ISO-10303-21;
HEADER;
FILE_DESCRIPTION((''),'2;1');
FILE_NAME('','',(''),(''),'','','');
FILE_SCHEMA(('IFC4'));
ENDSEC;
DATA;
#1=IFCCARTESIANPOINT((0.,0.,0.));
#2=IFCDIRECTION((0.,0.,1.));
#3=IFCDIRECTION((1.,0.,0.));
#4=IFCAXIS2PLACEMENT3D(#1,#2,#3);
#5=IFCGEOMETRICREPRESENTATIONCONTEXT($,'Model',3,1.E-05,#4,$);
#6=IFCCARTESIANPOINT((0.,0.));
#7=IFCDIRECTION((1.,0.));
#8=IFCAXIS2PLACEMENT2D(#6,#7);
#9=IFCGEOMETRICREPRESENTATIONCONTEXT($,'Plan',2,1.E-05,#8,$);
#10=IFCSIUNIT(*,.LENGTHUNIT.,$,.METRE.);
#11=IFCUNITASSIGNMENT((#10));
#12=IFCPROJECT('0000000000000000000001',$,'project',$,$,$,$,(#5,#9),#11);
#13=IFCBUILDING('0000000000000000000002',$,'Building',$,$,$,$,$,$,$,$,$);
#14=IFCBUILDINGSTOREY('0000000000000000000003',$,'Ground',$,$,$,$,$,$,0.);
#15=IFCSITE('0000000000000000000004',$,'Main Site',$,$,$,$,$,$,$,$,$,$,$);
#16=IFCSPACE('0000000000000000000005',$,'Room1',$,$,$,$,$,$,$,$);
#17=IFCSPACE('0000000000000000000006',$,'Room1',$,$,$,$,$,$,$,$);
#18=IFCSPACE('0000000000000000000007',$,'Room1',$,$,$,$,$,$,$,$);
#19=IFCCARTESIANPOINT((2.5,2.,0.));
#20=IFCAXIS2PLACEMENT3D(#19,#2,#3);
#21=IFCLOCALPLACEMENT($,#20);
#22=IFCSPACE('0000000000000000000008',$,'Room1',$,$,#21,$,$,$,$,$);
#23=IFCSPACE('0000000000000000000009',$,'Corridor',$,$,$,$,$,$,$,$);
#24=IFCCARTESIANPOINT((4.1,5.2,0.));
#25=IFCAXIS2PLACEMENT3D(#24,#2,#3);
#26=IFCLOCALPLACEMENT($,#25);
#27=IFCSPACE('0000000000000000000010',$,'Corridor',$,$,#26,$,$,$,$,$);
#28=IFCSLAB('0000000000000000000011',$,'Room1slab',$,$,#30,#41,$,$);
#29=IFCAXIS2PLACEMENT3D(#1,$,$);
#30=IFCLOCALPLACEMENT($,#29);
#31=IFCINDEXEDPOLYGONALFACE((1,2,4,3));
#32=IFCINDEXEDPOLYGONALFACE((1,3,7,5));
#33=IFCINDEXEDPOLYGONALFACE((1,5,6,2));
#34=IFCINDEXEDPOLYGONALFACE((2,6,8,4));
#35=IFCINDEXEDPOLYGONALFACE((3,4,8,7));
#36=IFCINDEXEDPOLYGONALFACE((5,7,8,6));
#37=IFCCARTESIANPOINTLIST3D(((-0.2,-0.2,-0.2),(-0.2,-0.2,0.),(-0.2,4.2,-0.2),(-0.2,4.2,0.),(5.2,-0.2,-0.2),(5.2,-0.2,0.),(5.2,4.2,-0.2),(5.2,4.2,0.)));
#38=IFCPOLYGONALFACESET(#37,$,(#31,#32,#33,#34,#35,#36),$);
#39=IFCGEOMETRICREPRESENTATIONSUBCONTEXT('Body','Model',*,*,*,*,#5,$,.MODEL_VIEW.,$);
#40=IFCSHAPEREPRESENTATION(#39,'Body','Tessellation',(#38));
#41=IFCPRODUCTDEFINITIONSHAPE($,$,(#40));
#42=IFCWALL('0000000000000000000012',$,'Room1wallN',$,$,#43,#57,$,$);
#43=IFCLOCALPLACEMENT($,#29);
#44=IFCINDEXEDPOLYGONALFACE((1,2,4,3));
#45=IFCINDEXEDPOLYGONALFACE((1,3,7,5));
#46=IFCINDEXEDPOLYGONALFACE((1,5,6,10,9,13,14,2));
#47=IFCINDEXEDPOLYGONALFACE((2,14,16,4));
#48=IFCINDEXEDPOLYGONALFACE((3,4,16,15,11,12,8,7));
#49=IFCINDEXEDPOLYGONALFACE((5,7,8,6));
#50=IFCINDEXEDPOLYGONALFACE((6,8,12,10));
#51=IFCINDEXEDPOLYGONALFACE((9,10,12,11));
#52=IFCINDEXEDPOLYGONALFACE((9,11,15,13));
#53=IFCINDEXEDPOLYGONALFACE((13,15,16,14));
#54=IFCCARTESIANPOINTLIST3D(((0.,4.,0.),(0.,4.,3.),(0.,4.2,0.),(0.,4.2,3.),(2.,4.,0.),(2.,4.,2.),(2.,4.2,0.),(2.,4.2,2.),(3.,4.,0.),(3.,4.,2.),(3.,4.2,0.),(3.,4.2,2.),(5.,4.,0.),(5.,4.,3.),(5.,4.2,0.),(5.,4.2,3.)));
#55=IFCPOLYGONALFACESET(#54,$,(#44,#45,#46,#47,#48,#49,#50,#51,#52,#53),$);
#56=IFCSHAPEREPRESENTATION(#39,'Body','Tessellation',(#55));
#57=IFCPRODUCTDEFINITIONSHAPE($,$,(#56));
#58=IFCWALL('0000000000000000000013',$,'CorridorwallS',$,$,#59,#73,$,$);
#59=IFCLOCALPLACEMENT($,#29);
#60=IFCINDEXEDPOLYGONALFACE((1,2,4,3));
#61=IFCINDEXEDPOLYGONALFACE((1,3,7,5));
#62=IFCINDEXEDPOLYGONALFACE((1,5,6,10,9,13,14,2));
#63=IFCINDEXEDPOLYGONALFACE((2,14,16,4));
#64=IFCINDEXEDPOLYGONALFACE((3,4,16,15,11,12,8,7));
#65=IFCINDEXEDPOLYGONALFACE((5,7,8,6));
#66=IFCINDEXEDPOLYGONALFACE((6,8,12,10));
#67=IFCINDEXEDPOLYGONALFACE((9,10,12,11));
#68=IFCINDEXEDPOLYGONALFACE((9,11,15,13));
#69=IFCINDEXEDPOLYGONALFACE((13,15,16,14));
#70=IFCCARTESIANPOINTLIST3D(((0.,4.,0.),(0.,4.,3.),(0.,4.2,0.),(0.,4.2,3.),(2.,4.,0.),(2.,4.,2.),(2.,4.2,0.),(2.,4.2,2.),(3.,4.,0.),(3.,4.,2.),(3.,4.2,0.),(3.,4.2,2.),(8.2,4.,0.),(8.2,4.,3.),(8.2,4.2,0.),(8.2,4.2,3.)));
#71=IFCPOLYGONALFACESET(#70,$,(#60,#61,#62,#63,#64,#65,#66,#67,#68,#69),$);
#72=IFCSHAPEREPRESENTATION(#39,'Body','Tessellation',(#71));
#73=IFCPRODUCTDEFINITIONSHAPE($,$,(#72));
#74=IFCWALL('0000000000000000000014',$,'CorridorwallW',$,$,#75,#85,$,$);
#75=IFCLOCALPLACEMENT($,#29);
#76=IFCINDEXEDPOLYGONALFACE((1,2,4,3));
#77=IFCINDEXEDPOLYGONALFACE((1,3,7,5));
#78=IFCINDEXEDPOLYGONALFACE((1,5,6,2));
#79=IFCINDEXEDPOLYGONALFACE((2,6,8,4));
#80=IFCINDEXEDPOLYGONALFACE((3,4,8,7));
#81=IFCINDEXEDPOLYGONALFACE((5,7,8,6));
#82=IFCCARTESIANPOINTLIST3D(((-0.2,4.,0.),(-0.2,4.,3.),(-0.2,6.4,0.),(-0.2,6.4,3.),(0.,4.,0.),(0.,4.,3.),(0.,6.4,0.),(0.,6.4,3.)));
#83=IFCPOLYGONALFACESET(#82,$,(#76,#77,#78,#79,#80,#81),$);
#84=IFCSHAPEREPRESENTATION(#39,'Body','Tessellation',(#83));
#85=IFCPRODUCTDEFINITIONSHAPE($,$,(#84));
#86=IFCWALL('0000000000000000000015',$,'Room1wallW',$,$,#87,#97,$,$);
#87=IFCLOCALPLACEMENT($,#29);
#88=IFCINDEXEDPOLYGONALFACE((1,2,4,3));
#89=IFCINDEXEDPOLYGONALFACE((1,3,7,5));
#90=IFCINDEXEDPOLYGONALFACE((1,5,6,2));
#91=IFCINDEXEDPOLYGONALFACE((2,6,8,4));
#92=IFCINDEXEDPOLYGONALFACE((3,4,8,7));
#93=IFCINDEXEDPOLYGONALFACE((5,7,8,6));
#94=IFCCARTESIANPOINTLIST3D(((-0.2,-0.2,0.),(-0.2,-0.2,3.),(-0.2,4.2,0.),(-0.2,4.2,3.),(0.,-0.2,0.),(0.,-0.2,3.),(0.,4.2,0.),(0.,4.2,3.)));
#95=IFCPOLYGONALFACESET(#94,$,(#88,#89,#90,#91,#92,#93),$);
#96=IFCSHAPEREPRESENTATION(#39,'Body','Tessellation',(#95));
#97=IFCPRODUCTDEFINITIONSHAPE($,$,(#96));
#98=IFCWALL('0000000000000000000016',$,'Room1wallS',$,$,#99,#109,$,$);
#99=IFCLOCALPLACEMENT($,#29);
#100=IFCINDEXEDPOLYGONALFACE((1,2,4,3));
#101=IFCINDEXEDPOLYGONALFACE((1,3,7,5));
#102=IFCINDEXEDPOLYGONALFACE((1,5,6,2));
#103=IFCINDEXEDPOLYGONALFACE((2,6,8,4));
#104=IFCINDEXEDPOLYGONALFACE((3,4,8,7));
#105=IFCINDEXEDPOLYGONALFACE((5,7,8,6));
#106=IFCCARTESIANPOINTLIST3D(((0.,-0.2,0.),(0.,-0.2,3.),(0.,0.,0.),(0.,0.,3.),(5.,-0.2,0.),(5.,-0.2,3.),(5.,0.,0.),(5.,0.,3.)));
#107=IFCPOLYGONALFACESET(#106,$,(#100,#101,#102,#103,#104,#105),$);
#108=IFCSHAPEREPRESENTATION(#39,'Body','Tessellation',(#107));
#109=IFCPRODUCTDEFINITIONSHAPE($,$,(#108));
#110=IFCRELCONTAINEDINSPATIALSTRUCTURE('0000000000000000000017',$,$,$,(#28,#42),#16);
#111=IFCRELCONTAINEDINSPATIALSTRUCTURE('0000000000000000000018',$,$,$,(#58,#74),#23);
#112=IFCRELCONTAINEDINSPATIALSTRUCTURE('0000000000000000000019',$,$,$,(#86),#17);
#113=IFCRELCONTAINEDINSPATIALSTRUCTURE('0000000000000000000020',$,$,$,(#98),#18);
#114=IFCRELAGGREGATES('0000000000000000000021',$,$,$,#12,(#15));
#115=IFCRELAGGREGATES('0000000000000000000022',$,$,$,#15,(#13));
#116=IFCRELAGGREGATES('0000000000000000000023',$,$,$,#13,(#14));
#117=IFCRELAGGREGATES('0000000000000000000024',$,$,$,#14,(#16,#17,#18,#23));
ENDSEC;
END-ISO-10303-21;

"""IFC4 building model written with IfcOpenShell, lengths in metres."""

from ifc_helpers import new_model, si_unit, frame, origin_with_axes, origin_2d_with_axis, place, context, subcontext, project, spatial, indexed_curve, rectangle, outline, extrude, element, save


model = new_model("IFC4")

# Units and contexts
model_context = context("Model", 3, precision=1e-05, world=origin_with_axes())
plan_context = context("Plan", 2, precision=1e-05, world=origin_2d_with_axis())
body_context = subcontext(model_context, "Body", "Model", "MODEL_VIEW")
ifc_project = project(units=[si_unit("LENGTHUNIT", "METRE")], contexts=[model_context, plan_context])

# Site, building, storey, space
site = spatial("IfcSite", under=ifc_project, Name="Main Site")
building = spatial("IfcBuilding", under=site, Name="Building")
storey = spatial("IfcBuildingStorey", under=building, Name="Ground", Elevation=0.0)
space_1 = spatial("IfcSpace", under=storey, Name="Room1")

# Slab
slab_1_placement = place(None, frame((2.5, 2.0, -0.2), z_axis=(0.0, 0.0, 1.0), x_axis=(1.0, 0.0, 0.0)))
element("IfcSlab", 1, at=slab_1_placement, inside=space_1, Name="Room1slab", context=body_context, shape_type="SweptSolid", body=[
    extrude(rectangle(XDim=5.4, YDim=4.4), origin_with_axes(), (0.0, 0.0, 1.0), 0.2),
])

# Shared definitions
space_2 = spatial("IfcSpace", under=storey, Name="Room1")

# Shared definitions
space_3 = spatial("IfcSpace", under=storey, Name="Room1")

# Wall
wall_1_placement = place(None, frame((0.0, 4.0, 0.0), z_axis=(0.0, 0.0, 1.0), x_axis=(1.0, 0.0, 0.0)))
wall_1 = element("IfcWall", 2, at=wall_1_placement, inside=space_1, Name="Room1wallN", context=body_context, shape_type="SweptSolid", body=[
    extrude(outline(indexed_curve([(0.0, 0.0), (0.0, 0.2), (5.0, 0.2), (5.0, 0.0), (0.0, 0.0)], self_intersect=False)), origin_with_axes(), (0.0, 0.0, 1.0), 3.0),
])

# Shared definitions
space_4_placement = place(None, frame((2.5, 2.0, 0.0), z_axis=(0.0, 0.0, 1.0), x_axis=(1.0, 0.0, 0.0)))
space_4 = spatial("IfcSpace", at=space_4_placement, Name="Room1")

# Opening
opening_1_placement = place(wall_1_placement, frame((2.0, 0.0, 0.0), z_axis=(0.0, 0.0, 1.0), x_axis=(1.0, 0.0, 0.0)))
element("IfcOpeningElement", 3, at=opening_1_placement, inside=space_4, cuts=wall_1, context=body_context, shape_type="SweptSolid", body=[
    extrude(outline(indexed_curve([(0.0, 0.0), (0.0, 0.4), (1.0, 0.4), (1.0, 0.0), (0.0, 0.0)], self_intersect=False)), origin_with_axes(), (0.0, 0.0, 1.0), 2.0),
])

# Shared definitions
space_5 = spatial("IfcSpace", under=storey, Name="Corridor")

# Wall
wall_2_placement = place(None, frame((0.0, 4.0, 0.0), z_axis=(0.0, 0.0, 1.0), x_axis=(1.0, 0.0, 0.0)))
wall_2 = element("IfcWall", 4, at=wall_2_placement, inside=space_5, Name="CorridorwallS", context=body_context, shape_type="SweptSolid", body=[
    extrude(outline(indexed_curve([(0.0, 0.0), (0.0, 0.2), (8.2, 0.2), (8.2, 0.0), (0.0, 0.0)], self_intersect=False)), origin_with_axes(), (0.0, 0.0, 1.0), 3.0),
])

# Shared definitions
space_6_placement = place(None, frame((4.1, 5.2, 0.0), z_axis=(0.0, 0.0, 1.0), x_axis=(1.0, 0.0, 0.0)))
space_6 = spatial("IfcSpace", at=space_6_placement, Name="Corridor")

# Opening
opening_2_placement = place(wall_2_placement, frame((2.0, 0.0, 0.0), z_axis=(0.0, 0.0, 1.0), x_axis=(1.0, 0.0, 0.0)))
element("IfcOpeningElement", 5, at=opening_2_placement, inside=space_6, cuts=wall_2, context=body_context, shape_type="SweptSolid", body=[
    extrude(outline(indexed_curve([(0.0, 0.0), (0.0, 0.4), (1.0, 0.4), (1.0, 0.0), (0.0, 0.0)], self_intersect=False)), origin_with_axes(), (0.0, 0.0, 1.0), 2.0),
])

# Wall
wall_3_placement = place(None, frame((0.0, 4.0, 0.0), z_axis=(0.0, 0.0, 1.0), x_axis=(0.0, 1.0, 0.0)))
element("IfcWall", 6, at=wall_3_placement, inside=space_5, Name="CorridorwallW", context=body_context, shape_type="SweptSolid", body=[
    extrude(outline(indexed_curve([(0.0, 0.0), (0.0, 0.2), (2.4, 0.2), (2.4, 0.0), (0.0, 0.0)], self_intersect=False)), origin_with_axes(), (0.0, 0.0, 1.0), 3.0),
])

# Walls
wall_4_placement = place(None, frame((0.0, -0.2, 0.0), z_axis=(0.0, 0.0, 1.0), x_axis=(0.0, 1.0, 0.0)))
element("IfcWall", 7, at=wall_4_placement, inside=space_2, Name="Room1wallW", context=body_context, shape_type="SweptSolid", body=[
    extrude(outline(indexed_curve([(0.0, 0.0), (0.0, 0.2), (4.4, 0.2), (4.4, 0.0), (0.0, 0.0)], self_intersect=False)), origin_with_axes(), (0.0, 0.0, 1.0), 3.0),
])
wall_5_placement = place(None, frame((0.0, -0.2, 0.0), z_axis=(0.0, 0.0, 1.0), x_axis=(1.0, 0.0, 0.0)))
element("IfcWall", 8, at=wall_5_placement, inside=space_3, Name="Room1wallS", context=body_context, shape_type="SweptSolid", body=[
    extrude(outline(indexed_curve([(0.0, 0.0), (0.0, 0.2), (5.0, 0.2), (5.0, 0.0), (0.0, 0.0)], self_intersect=False)), origin_with_axes(), (0.0, 0.0, 1.0), 3.0),
])

save(model, "model.ifc")
